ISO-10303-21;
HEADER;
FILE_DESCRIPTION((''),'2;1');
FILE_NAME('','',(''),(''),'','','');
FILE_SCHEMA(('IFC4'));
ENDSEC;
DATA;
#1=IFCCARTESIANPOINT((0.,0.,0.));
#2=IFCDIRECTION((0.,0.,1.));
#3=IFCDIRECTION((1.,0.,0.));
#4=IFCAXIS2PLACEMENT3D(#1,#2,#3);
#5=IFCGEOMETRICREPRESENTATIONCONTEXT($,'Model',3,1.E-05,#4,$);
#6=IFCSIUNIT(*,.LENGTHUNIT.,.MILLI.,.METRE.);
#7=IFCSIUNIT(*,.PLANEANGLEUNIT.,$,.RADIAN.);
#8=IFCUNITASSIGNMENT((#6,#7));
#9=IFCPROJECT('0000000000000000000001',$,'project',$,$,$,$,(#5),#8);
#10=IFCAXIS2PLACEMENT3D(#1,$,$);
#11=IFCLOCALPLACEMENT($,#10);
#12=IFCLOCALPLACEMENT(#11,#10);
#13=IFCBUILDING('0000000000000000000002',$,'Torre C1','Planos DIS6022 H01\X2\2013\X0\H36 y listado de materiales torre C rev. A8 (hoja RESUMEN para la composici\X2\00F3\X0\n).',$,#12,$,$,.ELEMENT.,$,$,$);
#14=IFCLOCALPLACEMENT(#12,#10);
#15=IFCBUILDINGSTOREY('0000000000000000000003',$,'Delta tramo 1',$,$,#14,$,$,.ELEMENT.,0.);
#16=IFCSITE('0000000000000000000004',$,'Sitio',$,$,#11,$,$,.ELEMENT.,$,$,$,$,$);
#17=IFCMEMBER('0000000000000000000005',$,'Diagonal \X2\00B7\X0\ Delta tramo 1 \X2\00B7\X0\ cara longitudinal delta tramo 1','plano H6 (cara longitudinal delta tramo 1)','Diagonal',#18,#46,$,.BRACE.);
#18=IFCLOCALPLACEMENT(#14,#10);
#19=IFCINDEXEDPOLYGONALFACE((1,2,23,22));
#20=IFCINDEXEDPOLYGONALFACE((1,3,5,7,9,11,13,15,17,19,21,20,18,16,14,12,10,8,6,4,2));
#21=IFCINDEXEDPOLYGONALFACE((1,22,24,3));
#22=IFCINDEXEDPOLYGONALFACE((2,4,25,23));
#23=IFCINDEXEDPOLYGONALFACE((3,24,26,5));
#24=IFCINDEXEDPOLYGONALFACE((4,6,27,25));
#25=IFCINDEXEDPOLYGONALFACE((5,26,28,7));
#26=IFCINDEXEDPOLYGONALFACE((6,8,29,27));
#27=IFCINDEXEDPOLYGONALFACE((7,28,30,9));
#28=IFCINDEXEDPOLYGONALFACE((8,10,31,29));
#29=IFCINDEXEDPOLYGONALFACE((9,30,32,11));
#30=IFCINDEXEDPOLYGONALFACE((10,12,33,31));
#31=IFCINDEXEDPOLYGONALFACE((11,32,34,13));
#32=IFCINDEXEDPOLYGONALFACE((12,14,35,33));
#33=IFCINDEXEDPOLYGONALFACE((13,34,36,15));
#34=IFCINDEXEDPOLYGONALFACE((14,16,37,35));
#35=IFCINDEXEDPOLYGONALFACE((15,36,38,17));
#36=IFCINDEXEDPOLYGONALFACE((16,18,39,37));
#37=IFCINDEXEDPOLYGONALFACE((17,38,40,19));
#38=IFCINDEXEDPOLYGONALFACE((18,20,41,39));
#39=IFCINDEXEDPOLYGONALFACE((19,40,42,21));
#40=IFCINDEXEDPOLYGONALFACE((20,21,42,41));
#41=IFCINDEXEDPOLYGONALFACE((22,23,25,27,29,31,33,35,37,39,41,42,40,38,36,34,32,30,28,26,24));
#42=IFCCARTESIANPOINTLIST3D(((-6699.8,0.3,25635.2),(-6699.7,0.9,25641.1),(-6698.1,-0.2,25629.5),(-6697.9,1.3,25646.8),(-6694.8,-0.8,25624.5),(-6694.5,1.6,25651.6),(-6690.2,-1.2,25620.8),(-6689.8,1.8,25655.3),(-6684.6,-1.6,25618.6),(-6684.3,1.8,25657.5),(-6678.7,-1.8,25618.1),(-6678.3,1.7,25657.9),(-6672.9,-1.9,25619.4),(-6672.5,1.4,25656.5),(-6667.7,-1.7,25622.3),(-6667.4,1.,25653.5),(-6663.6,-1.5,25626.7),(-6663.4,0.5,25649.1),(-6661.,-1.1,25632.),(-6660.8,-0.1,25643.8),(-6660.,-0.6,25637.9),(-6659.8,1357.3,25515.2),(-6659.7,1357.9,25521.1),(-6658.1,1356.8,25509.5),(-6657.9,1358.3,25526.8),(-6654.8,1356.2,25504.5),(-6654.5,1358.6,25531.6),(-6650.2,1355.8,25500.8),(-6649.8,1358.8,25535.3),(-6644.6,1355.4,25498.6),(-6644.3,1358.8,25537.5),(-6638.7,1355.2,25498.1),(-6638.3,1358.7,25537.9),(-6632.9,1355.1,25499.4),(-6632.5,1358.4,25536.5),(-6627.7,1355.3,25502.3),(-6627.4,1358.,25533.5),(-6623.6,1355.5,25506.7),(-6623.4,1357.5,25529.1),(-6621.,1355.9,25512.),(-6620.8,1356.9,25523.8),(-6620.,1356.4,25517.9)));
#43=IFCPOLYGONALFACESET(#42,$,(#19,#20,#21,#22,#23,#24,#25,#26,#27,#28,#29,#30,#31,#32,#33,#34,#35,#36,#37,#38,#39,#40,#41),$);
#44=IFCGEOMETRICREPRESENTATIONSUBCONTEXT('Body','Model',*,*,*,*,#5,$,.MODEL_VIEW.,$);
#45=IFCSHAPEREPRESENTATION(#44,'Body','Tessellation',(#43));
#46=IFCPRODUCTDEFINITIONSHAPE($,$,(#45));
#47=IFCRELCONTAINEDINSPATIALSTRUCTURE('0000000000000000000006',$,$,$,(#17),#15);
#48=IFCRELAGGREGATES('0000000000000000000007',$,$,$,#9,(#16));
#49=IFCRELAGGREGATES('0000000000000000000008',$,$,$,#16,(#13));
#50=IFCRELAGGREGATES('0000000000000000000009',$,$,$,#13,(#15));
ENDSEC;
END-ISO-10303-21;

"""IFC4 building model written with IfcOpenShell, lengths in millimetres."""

from ifc_helpers import new_model, si_unit, frame, origin, origin_with_axes, place, context, subcontext, project, spatial, circle, extrude, element, save


model = new_model("IFC4")

# Units and contexts
model_context = context("Model", 3, precision=1e-05, world=origin_with_axes())
body_context = subcontext(model_context, "Body", "Model", "MODEL_VIEW")
ifc_project = project(units=[si_unit("LENGTHUNIT", "METRE", prefix="MILLI"), si_unit("PLANEANGLEUNIT", "RADIAN")], contexts=[model_context])

# Site, building, storey
site_placement = place(None, origin())
site = spatial("IfcSite", under=ifc_project, at=site_placement, Name="Sitio", CompositionType="ELEMENT")
building_placement = place(site_placement, origin())
building = spatial("IfcBuilding", under=site, at=building_placement, Name="Torre C1", Description="Planos DIS6022 H01–H36 y listado de materiales torre C rev. A8 (hoja RESUMEN para la composición).", CompositionType="ELEMENT")
storey_placement = place(building_placement, origin())
storey = spatial("IfcBuildingStorey", under=building, at=storey_placement, Name="Delta tramo 1", CompositionType="ELEMENT", Elevation=0.0)

# Member
for number, where, z_axis, x_axis, name in (
    (1, (-6680.0, 0.0, 25638.0), (0.02935, 0.995684, -0.088049), (0.999529, -0.030023, -0.006331), "Diagonal · Delta tramo 1 · cara longitudinal delta tramo 1"),
):
    element("IfcMember", number, at=place(storey_placement, frame(where, z_axis=z_axis, x_axis=x_axis)), inside=storey, Name=name, Description="plano H6 (cara longitudinal delta tramo 1)", ObjectType="Diagonal", PredefinedType="BRACE", context=body_context, shape_type="SweptSolid", body=[
        extrude(circle(Radius=20.0), None, (0.0, 0.0, 1.0), 1362.9),
    ])

save(model, "model.ifc")
